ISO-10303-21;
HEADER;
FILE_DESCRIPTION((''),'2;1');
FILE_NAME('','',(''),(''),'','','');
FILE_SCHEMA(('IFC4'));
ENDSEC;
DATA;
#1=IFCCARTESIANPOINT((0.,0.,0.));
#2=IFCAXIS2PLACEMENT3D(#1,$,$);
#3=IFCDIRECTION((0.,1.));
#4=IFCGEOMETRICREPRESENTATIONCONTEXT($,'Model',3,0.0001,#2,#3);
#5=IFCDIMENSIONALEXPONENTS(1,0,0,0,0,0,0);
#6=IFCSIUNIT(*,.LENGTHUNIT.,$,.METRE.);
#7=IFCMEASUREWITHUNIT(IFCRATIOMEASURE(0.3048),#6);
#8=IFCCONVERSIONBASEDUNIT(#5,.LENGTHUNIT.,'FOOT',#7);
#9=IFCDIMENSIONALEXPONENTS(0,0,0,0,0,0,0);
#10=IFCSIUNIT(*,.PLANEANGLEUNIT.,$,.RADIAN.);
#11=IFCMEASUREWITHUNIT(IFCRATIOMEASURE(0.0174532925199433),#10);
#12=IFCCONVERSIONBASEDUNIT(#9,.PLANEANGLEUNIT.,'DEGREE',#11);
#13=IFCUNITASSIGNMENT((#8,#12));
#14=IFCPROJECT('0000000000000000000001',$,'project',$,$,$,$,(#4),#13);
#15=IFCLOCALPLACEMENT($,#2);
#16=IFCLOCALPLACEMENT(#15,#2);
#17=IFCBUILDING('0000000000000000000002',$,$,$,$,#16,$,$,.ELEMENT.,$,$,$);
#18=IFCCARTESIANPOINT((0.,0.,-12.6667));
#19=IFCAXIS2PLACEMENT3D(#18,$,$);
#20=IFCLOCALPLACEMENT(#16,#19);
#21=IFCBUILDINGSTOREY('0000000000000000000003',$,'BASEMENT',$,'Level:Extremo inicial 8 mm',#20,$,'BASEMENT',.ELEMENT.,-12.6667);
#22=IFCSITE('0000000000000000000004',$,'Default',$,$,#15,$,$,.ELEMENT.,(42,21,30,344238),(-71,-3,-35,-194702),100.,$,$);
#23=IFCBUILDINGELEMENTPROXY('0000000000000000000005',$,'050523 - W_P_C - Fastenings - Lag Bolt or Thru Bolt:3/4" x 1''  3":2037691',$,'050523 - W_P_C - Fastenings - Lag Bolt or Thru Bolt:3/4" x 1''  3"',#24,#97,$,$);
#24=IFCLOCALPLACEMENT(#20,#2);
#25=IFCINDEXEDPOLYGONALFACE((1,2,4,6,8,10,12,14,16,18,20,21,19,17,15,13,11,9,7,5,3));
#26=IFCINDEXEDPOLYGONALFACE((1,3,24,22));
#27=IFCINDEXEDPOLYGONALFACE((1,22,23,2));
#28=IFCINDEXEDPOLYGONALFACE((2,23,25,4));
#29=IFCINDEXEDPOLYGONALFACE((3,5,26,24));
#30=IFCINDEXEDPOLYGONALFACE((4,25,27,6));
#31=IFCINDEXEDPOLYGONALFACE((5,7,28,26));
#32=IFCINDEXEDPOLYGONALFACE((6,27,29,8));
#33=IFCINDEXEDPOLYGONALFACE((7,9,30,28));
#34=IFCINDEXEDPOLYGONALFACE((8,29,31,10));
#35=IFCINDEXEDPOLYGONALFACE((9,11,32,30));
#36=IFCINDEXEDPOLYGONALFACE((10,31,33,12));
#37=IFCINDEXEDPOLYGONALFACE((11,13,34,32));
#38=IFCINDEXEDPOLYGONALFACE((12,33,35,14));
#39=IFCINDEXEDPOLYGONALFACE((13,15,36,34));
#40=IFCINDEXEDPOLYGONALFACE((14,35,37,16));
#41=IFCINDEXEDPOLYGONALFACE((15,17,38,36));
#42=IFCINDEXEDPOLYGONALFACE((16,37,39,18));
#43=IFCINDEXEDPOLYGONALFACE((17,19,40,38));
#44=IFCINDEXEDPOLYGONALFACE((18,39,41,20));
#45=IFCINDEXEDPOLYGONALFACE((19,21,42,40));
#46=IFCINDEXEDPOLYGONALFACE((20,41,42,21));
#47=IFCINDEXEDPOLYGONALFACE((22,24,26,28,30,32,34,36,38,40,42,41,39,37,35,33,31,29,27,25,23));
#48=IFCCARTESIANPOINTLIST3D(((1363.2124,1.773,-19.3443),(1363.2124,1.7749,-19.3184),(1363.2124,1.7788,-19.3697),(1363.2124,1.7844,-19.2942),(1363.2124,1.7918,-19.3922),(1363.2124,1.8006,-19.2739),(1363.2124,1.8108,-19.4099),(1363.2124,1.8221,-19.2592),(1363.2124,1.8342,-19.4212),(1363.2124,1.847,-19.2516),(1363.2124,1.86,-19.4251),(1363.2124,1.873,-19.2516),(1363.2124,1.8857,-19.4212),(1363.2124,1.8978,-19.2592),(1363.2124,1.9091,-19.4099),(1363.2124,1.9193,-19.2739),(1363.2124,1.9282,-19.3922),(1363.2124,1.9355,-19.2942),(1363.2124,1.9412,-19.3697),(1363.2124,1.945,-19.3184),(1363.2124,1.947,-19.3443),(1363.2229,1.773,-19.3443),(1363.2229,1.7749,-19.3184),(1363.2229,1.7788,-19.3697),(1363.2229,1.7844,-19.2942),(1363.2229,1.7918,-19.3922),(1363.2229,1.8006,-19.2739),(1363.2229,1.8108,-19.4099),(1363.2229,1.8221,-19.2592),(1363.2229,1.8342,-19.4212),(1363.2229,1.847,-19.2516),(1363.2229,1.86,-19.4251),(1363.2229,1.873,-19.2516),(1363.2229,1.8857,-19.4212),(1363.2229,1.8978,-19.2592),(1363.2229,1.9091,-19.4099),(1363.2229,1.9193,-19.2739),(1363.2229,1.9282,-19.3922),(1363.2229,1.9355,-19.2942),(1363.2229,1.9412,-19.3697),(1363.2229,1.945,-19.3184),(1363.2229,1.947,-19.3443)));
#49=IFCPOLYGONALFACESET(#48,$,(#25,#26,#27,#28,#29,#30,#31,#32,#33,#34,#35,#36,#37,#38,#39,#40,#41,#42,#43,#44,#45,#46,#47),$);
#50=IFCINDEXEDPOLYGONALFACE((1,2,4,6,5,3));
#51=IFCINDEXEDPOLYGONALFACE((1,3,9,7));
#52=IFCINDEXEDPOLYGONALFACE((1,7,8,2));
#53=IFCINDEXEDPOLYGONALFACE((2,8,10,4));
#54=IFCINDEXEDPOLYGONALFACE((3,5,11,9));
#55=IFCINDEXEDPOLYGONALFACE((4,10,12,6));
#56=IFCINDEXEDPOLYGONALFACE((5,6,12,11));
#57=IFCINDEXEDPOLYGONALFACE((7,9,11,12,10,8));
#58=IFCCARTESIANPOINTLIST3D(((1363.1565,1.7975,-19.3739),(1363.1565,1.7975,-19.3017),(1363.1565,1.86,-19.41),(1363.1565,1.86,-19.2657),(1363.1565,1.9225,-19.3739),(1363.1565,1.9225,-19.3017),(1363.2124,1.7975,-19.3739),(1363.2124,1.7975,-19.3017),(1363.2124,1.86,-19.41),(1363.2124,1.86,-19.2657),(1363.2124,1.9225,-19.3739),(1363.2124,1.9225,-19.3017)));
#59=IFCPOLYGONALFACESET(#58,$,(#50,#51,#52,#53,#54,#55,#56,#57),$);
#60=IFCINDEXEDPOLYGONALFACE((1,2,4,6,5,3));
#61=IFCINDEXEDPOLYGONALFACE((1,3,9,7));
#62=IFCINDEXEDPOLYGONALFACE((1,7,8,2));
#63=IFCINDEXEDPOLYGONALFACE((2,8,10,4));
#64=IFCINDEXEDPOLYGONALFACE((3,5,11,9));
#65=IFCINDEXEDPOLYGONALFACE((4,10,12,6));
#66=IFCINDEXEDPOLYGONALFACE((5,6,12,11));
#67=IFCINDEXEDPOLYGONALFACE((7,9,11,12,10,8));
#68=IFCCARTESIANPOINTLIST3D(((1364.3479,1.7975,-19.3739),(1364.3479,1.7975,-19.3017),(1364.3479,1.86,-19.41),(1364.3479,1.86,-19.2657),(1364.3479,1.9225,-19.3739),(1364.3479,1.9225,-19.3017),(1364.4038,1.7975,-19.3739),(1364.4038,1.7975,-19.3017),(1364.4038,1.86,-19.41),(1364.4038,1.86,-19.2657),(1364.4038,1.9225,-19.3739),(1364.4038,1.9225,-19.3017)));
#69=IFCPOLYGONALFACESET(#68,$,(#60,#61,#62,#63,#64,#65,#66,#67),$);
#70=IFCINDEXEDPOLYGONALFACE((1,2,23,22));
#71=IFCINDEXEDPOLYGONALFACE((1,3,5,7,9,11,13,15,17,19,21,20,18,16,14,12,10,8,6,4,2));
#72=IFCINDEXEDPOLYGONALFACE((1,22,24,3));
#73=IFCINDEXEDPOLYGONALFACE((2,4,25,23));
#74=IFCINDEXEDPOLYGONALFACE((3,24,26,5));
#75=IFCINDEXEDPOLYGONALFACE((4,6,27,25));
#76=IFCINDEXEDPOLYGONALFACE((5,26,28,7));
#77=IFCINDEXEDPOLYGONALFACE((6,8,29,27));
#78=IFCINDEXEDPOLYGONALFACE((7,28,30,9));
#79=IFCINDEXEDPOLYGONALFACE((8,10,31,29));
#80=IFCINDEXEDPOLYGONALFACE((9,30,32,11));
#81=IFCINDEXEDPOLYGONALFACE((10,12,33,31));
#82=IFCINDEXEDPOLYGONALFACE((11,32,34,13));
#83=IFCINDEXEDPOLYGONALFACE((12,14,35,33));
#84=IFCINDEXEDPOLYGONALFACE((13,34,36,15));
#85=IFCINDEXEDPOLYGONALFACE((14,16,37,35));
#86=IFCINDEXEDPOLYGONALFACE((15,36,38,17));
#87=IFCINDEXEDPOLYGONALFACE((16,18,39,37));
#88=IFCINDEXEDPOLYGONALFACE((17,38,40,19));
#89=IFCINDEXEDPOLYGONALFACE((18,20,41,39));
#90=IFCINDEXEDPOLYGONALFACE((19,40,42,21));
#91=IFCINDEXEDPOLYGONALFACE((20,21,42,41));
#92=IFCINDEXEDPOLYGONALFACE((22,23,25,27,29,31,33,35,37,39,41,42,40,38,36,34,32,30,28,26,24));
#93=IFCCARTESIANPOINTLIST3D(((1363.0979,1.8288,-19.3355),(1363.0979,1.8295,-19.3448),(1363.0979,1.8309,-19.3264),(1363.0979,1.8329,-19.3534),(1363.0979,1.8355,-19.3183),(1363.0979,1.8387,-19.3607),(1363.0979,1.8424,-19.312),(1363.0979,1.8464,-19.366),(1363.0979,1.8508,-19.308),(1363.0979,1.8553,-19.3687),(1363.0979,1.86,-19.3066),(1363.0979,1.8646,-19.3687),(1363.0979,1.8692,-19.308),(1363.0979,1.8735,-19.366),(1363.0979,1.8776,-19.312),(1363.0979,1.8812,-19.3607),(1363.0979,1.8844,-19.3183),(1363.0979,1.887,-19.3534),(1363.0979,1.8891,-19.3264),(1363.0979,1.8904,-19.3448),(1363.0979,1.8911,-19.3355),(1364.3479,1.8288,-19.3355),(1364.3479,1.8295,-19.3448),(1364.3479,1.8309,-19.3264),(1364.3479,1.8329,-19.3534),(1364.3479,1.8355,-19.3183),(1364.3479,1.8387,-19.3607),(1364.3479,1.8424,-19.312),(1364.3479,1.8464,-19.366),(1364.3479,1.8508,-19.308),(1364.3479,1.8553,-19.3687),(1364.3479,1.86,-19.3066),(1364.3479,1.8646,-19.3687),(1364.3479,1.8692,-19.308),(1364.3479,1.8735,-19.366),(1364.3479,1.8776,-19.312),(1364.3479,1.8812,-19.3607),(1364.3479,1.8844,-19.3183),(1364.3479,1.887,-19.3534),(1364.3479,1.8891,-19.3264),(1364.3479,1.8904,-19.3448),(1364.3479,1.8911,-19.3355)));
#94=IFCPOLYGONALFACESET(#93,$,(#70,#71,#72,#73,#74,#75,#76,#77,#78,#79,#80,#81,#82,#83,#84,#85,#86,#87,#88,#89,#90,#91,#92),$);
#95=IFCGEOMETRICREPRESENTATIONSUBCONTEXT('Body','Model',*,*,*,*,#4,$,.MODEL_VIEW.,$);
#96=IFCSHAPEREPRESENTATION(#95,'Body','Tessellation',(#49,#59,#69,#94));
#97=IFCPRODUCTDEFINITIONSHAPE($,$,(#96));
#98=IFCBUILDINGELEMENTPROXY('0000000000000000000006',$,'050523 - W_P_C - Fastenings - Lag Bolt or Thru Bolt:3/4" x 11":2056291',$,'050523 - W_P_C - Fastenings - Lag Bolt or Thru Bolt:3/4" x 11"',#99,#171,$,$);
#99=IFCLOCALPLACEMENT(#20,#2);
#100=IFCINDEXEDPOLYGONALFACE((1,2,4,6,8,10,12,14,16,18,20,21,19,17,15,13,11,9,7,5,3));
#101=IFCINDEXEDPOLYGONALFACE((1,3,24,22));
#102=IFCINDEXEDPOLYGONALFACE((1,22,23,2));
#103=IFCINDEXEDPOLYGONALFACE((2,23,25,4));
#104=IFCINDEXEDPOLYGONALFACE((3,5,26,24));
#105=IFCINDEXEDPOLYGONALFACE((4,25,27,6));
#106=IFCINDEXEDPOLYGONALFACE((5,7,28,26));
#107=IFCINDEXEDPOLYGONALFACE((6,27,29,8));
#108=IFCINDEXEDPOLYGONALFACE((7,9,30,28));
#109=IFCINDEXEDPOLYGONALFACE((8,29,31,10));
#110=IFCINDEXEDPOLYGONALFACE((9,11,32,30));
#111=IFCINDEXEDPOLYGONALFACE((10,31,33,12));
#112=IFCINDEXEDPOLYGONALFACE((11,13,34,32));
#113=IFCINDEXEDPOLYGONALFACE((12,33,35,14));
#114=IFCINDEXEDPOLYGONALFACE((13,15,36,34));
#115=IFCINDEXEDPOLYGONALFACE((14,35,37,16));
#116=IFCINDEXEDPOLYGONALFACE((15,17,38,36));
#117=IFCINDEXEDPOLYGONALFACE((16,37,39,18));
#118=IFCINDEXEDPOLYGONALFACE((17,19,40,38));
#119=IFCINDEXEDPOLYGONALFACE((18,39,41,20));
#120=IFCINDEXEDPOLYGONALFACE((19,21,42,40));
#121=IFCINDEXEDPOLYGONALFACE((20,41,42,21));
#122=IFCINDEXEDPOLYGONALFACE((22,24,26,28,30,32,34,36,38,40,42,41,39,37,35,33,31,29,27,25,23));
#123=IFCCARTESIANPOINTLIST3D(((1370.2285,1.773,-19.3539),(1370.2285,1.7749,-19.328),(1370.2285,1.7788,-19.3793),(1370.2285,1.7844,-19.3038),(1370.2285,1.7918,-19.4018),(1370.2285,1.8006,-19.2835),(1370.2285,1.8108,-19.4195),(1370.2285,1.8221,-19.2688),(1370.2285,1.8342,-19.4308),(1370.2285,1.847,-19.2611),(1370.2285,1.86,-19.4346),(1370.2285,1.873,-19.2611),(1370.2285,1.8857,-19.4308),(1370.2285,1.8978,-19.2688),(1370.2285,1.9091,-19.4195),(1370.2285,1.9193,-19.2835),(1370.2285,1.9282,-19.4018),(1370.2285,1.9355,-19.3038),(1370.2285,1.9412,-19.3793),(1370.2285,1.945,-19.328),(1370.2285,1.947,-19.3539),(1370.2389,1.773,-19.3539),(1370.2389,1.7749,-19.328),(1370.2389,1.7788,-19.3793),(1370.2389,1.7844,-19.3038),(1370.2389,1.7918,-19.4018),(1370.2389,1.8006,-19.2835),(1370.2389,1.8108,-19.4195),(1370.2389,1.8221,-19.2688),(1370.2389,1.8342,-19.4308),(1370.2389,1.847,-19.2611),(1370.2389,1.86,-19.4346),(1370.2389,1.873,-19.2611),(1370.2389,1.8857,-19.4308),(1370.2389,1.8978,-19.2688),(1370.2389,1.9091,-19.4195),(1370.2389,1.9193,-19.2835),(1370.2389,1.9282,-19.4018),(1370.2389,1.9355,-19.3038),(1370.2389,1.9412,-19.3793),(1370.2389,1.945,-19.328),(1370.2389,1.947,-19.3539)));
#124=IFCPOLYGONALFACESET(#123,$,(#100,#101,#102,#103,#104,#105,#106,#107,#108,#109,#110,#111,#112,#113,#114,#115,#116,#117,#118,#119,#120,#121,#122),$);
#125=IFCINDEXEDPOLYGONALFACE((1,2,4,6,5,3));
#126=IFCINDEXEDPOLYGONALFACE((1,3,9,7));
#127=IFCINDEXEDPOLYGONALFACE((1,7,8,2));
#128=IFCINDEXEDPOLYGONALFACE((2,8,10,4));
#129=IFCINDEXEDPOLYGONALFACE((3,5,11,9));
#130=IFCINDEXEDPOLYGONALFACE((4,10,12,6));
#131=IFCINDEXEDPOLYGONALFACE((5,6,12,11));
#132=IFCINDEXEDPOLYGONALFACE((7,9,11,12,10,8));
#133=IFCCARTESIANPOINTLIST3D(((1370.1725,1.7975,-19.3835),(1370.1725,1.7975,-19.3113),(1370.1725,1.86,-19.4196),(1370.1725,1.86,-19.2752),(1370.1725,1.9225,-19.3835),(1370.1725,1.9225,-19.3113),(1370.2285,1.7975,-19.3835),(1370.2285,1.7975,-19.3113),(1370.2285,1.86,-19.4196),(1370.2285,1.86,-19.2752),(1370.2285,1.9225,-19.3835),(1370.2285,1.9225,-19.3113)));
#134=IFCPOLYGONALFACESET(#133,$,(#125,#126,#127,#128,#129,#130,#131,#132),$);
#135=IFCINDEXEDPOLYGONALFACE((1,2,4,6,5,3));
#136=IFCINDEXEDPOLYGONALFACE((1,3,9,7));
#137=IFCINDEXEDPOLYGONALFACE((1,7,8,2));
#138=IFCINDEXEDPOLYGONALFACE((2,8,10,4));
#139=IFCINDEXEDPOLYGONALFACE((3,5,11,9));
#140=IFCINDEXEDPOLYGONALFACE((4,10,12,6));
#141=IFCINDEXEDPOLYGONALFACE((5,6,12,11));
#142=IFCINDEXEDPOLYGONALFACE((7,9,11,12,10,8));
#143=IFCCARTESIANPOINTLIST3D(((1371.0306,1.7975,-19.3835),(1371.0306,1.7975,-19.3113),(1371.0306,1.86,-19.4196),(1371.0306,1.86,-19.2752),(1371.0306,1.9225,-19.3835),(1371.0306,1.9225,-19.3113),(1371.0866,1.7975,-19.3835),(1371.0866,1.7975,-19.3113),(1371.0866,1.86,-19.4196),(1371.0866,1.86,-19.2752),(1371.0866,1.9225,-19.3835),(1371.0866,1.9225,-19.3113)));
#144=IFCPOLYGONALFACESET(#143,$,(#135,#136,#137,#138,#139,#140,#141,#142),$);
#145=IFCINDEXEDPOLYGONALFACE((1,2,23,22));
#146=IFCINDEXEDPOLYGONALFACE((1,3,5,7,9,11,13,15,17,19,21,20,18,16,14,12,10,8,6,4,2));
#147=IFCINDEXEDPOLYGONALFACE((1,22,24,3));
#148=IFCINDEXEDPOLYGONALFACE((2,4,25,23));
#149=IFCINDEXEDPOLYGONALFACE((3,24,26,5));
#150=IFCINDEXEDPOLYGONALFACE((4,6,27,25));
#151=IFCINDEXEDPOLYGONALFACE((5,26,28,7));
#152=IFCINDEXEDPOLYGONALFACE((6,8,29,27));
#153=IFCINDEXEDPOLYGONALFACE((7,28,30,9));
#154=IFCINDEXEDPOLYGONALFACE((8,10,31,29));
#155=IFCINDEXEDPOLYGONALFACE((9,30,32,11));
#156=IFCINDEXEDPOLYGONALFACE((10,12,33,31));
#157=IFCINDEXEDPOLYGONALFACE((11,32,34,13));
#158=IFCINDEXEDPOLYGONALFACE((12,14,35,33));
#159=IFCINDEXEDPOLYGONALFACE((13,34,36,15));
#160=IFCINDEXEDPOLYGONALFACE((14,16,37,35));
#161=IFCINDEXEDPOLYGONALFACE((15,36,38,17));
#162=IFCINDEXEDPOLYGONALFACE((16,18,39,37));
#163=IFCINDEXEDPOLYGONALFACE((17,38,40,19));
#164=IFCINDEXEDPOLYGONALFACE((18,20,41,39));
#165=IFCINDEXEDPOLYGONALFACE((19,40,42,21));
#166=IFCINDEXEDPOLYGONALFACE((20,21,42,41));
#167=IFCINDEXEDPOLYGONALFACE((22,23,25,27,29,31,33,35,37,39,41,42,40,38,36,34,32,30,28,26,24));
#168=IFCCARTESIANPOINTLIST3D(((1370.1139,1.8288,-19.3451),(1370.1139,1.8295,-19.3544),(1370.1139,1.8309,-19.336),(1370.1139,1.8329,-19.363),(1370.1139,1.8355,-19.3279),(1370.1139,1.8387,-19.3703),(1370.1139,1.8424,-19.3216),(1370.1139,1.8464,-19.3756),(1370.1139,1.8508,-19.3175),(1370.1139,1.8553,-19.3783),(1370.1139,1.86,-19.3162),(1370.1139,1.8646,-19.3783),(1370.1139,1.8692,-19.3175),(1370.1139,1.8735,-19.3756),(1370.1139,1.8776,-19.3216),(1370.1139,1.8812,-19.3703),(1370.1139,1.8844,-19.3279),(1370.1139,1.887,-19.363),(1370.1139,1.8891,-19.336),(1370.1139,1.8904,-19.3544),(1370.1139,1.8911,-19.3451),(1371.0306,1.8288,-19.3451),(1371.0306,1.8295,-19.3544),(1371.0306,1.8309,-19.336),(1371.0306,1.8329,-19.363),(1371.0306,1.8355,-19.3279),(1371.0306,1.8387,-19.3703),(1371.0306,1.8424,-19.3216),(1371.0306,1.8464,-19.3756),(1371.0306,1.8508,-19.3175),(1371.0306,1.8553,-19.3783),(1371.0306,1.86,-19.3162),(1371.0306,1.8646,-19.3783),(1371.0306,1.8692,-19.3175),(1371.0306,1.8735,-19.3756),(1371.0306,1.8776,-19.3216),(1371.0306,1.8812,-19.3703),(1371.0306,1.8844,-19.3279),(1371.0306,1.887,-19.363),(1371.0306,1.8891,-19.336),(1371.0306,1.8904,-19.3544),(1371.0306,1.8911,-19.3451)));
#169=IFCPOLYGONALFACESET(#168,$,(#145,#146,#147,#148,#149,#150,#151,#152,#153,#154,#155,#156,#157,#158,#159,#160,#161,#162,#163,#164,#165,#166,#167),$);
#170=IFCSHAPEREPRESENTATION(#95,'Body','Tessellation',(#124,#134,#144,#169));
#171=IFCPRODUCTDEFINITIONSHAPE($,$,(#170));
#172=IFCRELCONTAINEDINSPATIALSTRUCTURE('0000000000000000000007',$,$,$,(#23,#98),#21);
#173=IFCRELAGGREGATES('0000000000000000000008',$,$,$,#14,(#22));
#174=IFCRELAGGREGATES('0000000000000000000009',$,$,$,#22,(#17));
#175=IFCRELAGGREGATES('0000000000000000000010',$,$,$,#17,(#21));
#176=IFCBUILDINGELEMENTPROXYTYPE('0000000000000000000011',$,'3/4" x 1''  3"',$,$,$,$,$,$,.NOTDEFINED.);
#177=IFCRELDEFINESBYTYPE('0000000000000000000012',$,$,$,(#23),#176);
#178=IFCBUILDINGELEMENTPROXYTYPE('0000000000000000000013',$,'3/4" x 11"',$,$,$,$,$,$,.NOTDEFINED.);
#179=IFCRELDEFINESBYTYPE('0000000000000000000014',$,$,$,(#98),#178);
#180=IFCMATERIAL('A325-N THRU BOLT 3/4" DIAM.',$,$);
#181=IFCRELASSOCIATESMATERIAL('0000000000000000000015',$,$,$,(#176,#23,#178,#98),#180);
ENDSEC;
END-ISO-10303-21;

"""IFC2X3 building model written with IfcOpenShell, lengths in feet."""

from ifc_helpers import new_model, entity, si_unit, converted_unit, direction, frame, frame_2d, origin, place, context, subcontext, project, spatial, polyline, circle, outline, extrude, source, transform, mapped, material, type_object, type_shapes, element, save


model = new_model("IFC2X3")

# Units and contexts
model_context = context("Model", 3, precision=0.0001, world=origin(), true_north=direction((0.0, 1.0)))
body_context = subcontext(model_context, "Body", "Model", "MODEL_VIEW")
ifc_project = project(units=[converted_unit("LENGTHUNIT", "FOOT", entity("IfcRatioMeasure", 0.3048), si_unit("LENGTHUNIT", "METRE"), dimensions=[1, 0, 0, 0, 0, 0, 0]), converted_unit("PLANEANGLEUNIT", "DEGREE", entity("IfcRatioMeasure", 0.0174532925199433), si_unit("PLANEANGLEUNIT", "RADIAN"), dimensions=[0, 0, 0, 0, 0, 0, 0])], contexts=[model_context])

# Site, building, storey
site_placement = place(None, origin())
site = spatial("IfcSite", under=ifc_project, at=site_placement, Name="Default", CompositionType="ELEMENT", RefLatitude=(42, 21, 30, 344238), RefLongitude=(-71, -3, -35, -194702), RefElevation=100.0)
building_placement = place(site_placement, origin())
building = spatial("IfcBuilding", under=site, at=building_placement, CompositionType="ELEMENT")
storey_placement = place(building_placement, frame((0.0, 0.0, -12.6667)))
storey = spatial("IfcBuildingStorey", under=building, at=storey_placement, Name="BASEMENT", ObjectType="Level:Extremo inicial 8 mm", LongName="BASEMENT", CompositionType="ELEMENT", Elevation=-12.6667)

# Building element proxies
ifc_material_1 = material(Name="A325-N THRU BOLT 3/4\" DIAM.")
building_element_proxy_type_1 = type_object("IfcBuildingElementProxyType", Name="3/4\" x 1'  3\"", PredefinedType="NOTDEFINED", material=ifc_material_1)
shared_shape_1 = source(origin(), body_context, "Body", "SweptSolid", [
    extrude(circle(Radius=0.0872, at=frame_2d((0.0, 0.0), x_axis=(1.0, 0.0))), frame((0.0, 0.0, -1.1354), z_axis=(0.0, 0.0, 1.0), x_axis=(0.0, -1.0, 0.0)), (0.0, 0.0, 1.0), 0.0104),
    extrude(outline(polyline([(-0.0361, -0.0625), (0.0361, -0.0625), (0.0722, 0.0), (0.0361, 0.0625), (-0.0361, 0.0625), (-0.0722, 0.0), (-0.0361, -0.0625)])), frame((0.0, 0.0, -1.1914), z_axis=(0.0, 0.0, 1.0), x_axis=(0.866025, -0.5, 0.0)), (0.0, 0.0, 1.0), 0.056),
    extrude(outline(polyline([(-0.0361, -0.0625), (0.0361, -0.0625), (0.0722, 0.0), (0.0361, 0.0625), (-0.0361, 0.0625), (-0.0722, 0.0), (-0.0361, -0.0625)])), frame((0.0, 0.0, 0.0), z_axis=(0.0, 0.0, 1.0), x_axis=(0.0, -1.0, 0.0)), (0.0, 0.0, 1.0), 0.056),
    extrude(circle(Radius=0.0312, at=frame_2d((0.0, 0.0), x_axis=(1.0, 0.0))), frame((0.0, 0.0, -1.25), z_axis=(0.0, 0.0, 1.0), x_axis=(0.0, 1.0, 0.0)), (0.0, 0.0, 1.0), 1.25),
])
type_shapes(building_element_proxy_type_1, [shared_shape_1])
proxy_1_placement = place(storey_placement, frame((1364.3479, 1.86, -19.3378), z_axis=(1.0, 0.0, 0.0), x_axis=(0.0, 1.0, 0.0)))
element("IfcBuildingElementProxy", 1, at=proxy_1_placement, inside=storey, type_object=building_element_proxy_type_1, material=ifc_material_1, Name="050523 - W_P_C - Fastenings - Lag Bolt or Thru Bolt:3/4\" x 1'  3\":2037691", ObjectType="050523 - W_P_C - Fastenings - Lag Bolt or Thru Bolt:3/4\" x 1'  3\"", context=body_context, shape_type="MappedRepresentation", body=[
    mapped(shared_shape_1, transform((0.0, 0.0, 0.0), scale=1.0)),
])
building_element_proxy_type_2 = type_object("IfcBuildingElementProxyType", Name="3/4\" x 11\"", PredefinedType="NOTDEFINED", material=ifc_material_1)
shared_shape_2 = source(origin(), body_context, "Body", "SweptSolid", [
    extrude(circle(Radius=0.0872, at=frame_2d((0.0, 0.0), x_axis=(1.0, 0.0))), frame((0.0, 0.0, -0.8021), z_axis=(0.0, 0.0, 1.0), x_axis=(0.0, -1.0, 0.0)), (0.0, 0.0, 1.0), 0.0104),
    extrude(outline(polyline([(-0.0361, -0.0625), (0.0361, -0.0625), (0.0722, 0.0), (0.0361, 0.0625), (-0.0361, 0.0625), (-0.0722, 0.0), (-0.0361, -0.0625)])), frame((0.0, 0.0, -0.8581), z_axis=(0.0, 0.0, 1.0), x_axis=(0.866025, -0.5, 0.0)), (0.0, 0.0, 1.0), 0.056),
    extrude(outline(polyline([(-0.0361, -0.0625), (0.0361, -0.0625), (0.0722, 0.0), (0.0361, 0.0625), (-0.0361, 0.0625), (-0.0722, 0.0), (-0.0361, -0.0625)])), frame((0.0, 0.0, 0.0), z_axis=(0.0, 0.0, 1.0), x_axis=(0.0, -1.0, 0.0)), (0.0, 0.0, 1.0), 0.056),
    extrude(circle(Radius=0.0312, at=frame_2d((0.0, 0.0), x_axis=(1.0, 0.0))), frame((0.0, 0.0, -0.9167), z_axis=(0.0, 0.0, 1.0), x_axis=(0.0, 1.0, 0.0)), (0.0, 0.0, 1.0), 0.9167),
])
type_shapes(building_element_proxy_type_2, [shared_shape_2])
proxy_2_placement = place(storey_placement, frame((1371.0306, 1.86, -19.3474), z_axis=(1.0, 0.0, 0.0), x_axis=(0.0, 1.0, 0.0)))
element("IfcBuildingElementProxy", 2, at=proxy_2_placement, inside=storey, type_object=building_element_proxy_type_2, material=ifc_material_1, Name="050523 - W_P_C - Fastenings - Lag Bolt or Thru Bolt:3/4\" x 11\":2056291", ObjectType="050523 - W_P_C - Fastenings - Lag Bolt or Thru Bolt:3/4\" x 11\"", context=body_context, shape_type="MappedRepresentation", body=[
    mapped(shared_shape_2, transform((0.0, 0.0, 0.0), scale=1.0)),
])

save(model, "model.ifc")
